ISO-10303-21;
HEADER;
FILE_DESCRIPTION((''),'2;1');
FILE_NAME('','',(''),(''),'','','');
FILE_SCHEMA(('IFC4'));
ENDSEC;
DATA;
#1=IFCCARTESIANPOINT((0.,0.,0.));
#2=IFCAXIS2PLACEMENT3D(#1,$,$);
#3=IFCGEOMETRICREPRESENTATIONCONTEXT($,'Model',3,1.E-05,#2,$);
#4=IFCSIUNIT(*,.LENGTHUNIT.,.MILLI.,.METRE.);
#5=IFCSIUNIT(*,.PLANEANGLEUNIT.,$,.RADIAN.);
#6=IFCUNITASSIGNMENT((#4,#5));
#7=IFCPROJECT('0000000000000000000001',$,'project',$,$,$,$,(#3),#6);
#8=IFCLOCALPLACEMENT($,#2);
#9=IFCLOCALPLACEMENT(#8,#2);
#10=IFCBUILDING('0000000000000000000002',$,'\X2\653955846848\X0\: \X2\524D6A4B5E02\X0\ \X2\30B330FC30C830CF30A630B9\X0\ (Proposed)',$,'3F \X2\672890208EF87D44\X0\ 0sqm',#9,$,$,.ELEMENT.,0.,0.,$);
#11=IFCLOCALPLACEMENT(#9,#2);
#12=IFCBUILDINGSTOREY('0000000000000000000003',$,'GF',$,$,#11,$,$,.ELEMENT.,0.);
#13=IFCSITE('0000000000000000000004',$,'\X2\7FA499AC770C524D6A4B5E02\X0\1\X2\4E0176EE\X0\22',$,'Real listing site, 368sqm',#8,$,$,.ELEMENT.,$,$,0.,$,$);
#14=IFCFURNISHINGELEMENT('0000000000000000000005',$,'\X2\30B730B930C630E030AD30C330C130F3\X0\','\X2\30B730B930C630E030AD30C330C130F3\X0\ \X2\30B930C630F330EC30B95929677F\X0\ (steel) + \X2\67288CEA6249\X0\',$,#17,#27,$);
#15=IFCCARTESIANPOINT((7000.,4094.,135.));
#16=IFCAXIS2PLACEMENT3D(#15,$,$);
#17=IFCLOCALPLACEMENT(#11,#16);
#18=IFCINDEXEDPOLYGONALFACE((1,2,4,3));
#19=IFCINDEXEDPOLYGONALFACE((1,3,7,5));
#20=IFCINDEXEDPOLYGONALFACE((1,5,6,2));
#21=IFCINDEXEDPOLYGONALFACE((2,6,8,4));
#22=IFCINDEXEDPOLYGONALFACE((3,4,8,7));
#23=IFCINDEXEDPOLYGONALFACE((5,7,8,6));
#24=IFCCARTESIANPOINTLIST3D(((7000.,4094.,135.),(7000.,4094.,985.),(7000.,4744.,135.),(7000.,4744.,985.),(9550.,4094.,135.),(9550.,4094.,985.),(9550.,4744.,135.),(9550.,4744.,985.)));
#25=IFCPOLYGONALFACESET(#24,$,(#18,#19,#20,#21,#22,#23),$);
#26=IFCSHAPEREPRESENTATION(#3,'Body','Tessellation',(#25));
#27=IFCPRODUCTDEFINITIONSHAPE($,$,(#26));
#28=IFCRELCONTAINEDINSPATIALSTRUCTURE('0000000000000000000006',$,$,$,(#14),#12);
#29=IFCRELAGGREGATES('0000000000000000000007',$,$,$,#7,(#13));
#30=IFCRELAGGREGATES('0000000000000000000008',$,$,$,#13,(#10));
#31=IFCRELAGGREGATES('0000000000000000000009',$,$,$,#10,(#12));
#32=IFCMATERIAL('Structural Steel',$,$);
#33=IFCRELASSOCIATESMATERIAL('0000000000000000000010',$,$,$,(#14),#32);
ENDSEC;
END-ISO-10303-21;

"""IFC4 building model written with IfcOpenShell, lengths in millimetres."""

from ifc_helpers import new_model, si_unit, frame, frame_2d, origin, place, context, project, spatial, rectangle, extrude, material, element, save


model = new_model("IFC4")

# Units and contexts
model_context = context("Model", 3, precision=1e-05, world=origin())
ifc_project = project(units=[si_unit("LENGTHUNIT", "METRE", prefix="MILLI"), si_unit("PLANEANGLEUNIT", "RADIAN")], contexts=[model_context])

# Site, building, storey
site_placement = place(None, origin())
site = spatial("IfcSite", under=ifc_project, at=site_placement, Name="群馬県前橋市1丁目22", ObjectType="Real listing site, 368sqm", CompositionType="ELEMENT", RefElevation=0.0)
building_placement = place(site_placement, origin())
building = spatial("IfcBuilding", under=site, at=building_placement, Name="改善案: 前橋市 コートハウス (Proposed)", ObjectType="3F 木造軸組 0sqm", CompositionType="ELEMENT", ElevationOfRefHeight=0.0, ElevationOfTerrain=0.0)
storey_placement = place(building_placement, origin())
storey = spatial("IfcBuildingStorey", under=building, at=storey_placement, Name="GF", CompositionType="ELEMENT", Elevation=0.0)

# Furnishing element
ifc_material_1 = material(Name="Structural Steel")
furnishing_1_placement = place(storey_placement, frame((7000.0, 4094.0, 135.0)))
element("IfcFurnishingElement", 1, at=furnishing_1_placement, inside=storey, material=ifc_material_1, Name="システムキッチン", Description="システムキッチン ステンレス天板 (steel) + 木質扉", context=model_context, shape_type="SweptSolid", body=[
    extrude(rectangle(XDim=2550.0, YDim=650.0, at=frame_2d((1275.0, 325.0))), frame((7000.0, 4094.0, 135.0)), (0.0, 0.0, 1.0), 850.0),
])

save(model, "model.ifc")
